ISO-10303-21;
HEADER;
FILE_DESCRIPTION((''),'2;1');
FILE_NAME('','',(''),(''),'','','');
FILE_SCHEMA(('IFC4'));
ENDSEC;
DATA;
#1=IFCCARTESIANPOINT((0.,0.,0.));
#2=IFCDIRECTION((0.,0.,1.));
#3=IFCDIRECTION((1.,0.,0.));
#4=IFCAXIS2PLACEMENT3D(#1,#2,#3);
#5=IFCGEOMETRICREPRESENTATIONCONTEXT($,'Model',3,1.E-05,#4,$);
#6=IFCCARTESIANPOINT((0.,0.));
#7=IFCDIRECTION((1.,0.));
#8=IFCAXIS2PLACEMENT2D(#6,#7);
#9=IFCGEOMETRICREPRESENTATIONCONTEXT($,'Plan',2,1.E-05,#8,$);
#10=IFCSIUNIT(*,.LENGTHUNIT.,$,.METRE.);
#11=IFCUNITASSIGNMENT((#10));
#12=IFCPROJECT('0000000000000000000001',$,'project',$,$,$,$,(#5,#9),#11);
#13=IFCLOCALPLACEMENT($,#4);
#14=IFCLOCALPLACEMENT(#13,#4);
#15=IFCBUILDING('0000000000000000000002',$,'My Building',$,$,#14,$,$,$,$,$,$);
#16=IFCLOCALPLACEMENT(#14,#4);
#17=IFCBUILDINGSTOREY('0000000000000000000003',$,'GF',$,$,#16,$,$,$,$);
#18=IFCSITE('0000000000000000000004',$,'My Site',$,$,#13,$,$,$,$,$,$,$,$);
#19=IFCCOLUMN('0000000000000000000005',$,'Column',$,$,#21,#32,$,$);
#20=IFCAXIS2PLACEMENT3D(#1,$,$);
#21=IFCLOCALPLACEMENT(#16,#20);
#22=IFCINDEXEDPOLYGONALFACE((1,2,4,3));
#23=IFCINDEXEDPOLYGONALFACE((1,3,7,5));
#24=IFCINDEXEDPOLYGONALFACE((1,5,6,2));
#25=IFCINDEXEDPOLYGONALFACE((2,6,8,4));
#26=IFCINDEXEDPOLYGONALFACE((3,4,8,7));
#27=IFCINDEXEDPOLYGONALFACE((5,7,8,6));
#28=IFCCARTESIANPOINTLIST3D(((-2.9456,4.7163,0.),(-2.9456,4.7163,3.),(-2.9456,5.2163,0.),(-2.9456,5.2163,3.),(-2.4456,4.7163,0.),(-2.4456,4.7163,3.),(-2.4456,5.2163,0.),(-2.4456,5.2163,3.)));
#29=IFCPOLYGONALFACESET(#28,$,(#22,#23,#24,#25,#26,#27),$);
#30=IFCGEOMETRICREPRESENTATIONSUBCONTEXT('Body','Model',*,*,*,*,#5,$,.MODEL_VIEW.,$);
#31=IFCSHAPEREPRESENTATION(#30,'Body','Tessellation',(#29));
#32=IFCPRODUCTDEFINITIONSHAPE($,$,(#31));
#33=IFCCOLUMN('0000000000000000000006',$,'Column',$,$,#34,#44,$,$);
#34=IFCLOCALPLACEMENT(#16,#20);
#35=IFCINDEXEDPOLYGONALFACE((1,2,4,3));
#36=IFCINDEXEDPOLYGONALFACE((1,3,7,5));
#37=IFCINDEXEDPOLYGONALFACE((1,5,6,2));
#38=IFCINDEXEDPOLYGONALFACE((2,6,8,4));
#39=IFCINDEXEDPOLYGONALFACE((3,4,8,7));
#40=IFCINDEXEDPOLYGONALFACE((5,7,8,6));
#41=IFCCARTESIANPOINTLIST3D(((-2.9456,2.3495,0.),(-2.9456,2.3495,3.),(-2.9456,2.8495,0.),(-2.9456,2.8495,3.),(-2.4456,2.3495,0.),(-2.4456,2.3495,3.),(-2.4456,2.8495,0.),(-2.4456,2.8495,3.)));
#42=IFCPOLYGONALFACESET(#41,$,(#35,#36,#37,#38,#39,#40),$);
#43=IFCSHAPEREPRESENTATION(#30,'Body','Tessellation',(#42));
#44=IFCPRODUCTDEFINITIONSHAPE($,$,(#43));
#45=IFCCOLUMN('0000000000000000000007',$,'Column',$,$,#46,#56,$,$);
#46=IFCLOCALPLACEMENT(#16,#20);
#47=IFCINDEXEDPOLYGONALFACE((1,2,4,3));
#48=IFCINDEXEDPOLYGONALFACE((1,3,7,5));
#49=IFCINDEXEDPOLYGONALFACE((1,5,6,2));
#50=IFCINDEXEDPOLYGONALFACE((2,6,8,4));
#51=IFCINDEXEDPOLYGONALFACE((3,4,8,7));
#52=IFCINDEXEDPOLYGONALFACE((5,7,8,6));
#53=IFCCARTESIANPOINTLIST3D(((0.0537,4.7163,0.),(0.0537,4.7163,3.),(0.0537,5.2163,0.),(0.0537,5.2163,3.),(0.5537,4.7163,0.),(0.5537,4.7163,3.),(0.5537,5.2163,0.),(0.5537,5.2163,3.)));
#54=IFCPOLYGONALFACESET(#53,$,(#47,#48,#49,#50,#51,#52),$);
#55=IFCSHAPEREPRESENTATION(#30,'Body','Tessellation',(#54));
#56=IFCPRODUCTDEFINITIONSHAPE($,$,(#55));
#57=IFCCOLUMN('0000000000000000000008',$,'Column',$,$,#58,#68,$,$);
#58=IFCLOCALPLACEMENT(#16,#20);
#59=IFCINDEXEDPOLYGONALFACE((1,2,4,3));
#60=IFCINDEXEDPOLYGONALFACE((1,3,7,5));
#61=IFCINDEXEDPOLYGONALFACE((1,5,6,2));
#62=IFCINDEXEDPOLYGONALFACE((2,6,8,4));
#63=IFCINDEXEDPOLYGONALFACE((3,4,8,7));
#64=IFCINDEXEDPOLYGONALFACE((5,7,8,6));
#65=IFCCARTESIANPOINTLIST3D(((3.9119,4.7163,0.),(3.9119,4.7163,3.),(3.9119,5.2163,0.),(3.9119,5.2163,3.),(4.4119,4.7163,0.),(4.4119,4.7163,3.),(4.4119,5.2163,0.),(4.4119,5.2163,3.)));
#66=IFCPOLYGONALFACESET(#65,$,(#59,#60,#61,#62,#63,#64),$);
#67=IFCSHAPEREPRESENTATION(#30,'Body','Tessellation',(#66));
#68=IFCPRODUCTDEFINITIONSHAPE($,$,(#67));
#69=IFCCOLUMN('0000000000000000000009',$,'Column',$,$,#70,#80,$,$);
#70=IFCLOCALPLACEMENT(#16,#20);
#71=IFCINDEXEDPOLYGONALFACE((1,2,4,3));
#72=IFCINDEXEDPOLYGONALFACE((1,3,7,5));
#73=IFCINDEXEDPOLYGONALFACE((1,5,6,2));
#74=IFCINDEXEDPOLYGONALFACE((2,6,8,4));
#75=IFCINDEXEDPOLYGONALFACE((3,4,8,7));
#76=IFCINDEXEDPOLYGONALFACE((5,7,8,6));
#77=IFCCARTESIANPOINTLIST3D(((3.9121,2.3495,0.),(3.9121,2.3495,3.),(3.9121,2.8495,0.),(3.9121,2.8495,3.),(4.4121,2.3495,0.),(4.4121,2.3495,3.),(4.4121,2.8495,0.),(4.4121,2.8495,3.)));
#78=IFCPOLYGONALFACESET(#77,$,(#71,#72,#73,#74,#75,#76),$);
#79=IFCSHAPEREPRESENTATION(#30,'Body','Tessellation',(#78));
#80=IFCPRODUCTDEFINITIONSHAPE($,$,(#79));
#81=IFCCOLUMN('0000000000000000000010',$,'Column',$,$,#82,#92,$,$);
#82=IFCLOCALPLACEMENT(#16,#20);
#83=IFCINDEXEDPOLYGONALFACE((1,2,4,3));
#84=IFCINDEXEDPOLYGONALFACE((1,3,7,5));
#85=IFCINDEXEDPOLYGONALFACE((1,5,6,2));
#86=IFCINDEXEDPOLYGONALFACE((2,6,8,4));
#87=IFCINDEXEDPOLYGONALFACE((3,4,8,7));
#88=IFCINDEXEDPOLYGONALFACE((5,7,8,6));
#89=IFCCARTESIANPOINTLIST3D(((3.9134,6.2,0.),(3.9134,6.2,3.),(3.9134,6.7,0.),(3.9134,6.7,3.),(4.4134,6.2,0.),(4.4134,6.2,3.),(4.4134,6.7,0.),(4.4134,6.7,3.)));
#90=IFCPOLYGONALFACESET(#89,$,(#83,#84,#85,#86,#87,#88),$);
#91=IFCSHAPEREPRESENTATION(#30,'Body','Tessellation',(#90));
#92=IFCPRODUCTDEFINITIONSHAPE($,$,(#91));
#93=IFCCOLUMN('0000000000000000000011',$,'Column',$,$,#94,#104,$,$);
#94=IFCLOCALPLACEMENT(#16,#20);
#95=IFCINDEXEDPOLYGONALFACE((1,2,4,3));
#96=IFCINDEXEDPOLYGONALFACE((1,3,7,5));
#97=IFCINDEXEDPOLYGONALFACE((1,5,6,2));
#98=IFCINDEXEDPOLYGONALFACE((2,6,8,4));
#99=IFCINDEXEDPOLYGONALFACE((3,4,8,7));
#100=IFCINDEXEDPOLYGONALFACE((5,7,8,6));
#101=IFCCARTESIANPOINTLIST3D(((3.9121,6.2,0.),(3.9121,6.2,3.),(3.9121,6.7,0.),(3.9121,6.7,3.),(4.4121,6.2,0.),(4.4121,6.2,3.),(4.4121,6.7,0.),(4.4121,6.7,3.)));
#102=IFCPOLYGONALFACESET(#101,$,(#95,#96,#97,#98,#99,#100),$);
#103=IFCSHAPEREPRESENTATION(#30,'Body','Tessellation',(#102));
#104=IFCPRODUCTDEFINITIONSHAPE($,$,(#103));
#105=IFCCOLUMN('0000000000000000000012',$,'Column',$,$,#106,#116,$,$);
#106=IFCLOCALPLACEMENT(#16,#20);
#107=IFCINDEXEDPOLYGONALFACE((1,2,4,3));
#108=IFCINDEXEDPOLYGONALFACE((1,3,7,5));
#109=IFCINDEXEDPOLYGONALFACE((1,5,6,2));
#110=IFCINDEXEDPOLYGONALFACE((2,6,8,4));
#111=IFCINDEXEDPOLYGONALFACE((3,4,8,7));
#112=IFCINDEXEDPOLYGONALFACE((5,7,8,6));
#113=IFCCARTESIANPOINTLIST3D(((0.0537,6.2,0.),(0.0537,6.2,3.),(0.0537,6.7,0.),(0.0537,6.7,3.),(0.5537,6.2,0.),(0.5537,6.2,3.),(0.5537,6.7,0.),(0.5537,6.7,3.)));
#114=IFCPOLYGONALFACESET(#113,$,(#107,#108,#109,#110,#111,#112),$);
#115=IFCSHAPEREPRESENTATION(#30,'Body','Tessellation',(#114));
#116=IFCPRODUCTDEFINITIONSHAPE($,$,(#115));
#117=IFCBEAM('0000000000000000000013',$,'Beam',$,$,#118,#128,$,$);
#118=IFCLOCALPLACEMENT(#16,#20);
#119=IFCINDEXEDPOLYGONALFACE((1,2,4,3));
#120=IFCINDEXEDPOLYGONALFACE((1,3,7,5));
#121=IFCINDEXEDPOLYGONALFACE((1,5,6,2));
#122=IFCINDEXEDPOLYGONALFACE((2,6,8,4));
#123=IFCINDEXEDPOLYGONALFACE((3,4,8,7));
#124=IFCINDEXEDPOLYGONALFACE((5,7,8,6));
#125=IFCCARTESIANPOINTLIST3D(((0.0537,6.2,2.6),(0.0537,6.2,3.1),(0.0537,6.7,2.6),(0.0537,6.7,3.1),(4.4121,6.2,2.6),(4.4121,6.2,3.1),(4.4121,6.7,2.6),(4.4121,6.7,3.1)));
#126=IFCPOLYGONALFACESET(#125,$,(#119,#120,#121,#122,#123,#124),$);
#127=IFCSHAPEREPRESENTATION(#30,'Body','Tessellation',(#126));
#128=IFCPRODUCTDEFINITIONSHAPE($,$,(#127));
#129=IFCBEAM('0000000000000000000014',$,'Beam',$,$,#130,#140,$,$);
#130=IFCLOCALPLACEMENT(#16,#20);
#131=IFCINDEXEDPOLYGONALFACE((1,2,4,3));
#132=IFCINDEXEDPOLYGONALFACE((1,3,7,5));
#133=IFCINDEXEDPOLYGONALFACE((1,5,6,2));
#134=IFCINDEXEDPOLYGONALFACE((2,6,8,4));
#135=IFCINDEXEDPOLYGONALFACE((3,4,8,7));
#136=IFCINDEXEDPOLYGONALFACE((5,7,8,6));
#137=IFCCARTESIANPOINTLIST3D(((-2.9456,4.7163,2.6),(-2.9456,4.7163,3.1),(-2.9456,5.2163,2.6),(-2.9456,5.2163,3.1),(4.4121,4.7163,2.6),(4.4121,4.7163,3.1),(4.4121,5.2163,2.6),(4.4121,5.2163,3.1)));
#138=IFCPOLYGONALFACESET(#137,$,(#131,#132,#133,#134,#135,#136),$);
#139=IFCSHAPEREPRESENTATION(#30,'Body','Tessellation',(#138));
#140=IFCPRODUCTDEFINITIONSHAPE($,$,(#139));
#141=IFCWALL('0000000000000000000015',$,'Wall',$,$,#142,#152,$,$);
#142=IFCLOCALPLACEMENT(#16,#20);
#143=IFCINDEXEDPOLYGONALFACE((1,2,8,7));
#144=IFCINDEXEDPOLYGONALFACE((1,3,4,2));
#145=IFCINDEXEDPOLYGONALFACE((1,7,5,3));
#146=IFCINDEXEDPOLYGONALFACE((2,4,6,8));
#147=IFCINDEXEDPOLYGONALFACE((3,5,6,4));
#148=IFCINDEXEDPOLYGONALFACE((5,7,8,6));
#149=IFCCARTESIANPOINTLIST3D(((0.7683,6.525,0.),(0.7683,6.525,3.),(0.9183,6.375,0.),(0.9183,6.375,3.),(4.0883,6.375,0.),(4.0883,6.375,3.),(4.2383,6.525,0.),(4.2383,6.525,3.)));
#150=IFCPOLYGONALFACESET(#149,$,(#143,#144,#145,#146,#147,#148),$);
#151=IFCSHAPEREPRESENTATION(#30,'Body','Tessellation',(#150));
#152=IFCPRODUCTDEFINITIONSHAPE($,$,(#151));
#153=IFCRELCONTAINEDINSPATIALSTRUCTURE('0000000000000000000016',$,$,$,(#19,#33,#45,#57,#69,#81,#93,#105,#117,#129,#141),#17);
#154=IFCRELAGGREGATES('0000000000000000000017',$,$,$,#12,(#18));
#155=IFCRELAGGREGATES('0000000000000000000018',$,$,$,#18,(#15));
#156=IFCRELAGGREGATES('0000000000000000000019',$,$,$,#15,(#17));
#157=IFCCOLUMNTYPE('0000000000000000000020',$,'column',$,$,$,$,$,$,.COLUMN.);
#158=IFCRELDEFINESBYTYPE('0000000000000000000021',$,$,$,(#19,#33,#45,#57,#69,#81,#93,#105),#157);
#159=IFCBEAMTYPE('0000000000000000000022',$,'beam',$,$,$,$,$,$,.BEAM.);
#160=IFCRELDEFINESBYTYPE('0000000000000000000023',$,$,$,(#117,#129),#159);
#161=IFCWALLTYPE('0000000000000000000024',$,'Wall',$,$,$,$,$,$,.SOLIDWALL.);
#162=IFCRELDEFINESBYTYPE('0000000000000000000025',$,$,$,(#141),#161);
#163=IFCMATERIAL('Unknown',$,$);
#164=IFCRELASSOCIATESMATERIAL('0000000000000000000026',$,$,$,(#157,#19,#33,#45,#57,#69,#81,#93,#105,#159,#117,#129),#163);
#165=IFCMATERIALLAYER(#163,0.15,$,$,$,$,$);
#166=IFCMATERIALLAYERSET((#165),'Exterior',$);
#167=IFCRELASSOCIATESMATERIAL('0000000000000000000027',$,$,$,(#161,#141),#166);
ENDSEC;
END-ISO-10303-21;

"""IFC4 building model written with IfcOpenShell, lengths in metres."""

from ifc_helpers import new_model, si_unit, frame, origin_with_axes, origin_2d_with_axis, place, context, subcontext, project, spatial, line, indexed_curve, rectangle, outline, extrude, material, layer, layer_set, layer_usage, material_profile, profile_set, profile_usage, type_object, element, save


model = new_model("IFC4")

# Units and contexts
model_context = context("Model", 3, precision=1e-05, world=origin_with_axes())
plan_context = context("Plan", 2, precision=1e-05, world=origin_2d_with_axis())
body_context_1 = subcontext(model_context, "Body", "Model", "MODEL_VIEW")
ifc_project = project(units=[si_unit("LENGTHUNIT", "METRE")], contexts=[model_context, plan_context])

# Site, building, storey
site_placement = place(None, origin_with_axes())
site = spatial("IfcSite", under=ifc_project, at=site_placement, Name="My Site")
building_placement = place(site_placement, origin_with_axes())
building = spatial("IfcBuilding", under=site, at=building_placement, Name="My Building")
storey_placement = place(building_placement, origin_with_axes())
storey = spatial("IfcBuildingStorey", under=building, at=storey_placement, Name="GF")

# Columns
ifc_material = material(Name="Unknown")
ifc_material_profile_1 = material_profile(ifc_material, rectangle(XDim=0.5, YDim=0.5))
ifc_profile_set_1 = profile_set([ifc_material_profile_1])
ifc_profile_usage_1 = profile_usage(ifc_profile_set_1, cardinal=5)
column_type = type_object("IfcColumnType", Name="column", PredefinedType="COLUMN", material=ifc_profile_set_1)
column_1_placement = place(storey_placement, frame((-2.6956, 4.9663, 0.0), z_axis=(0.0, 0.0, 1.0), x_axis=(1.0, 0.0, 0.0)))
element("IfcColumn", 1, at=column_1_placement, inside=storey, type_object=column_type, material=ifc_profile_usage_1, Name="Column", context=body_context_1, shape_type="SweptSolid", body=[
    extrude(rectangle(XDim=0.5, YDim=0.5), origin_with_axes(), (0.0, 0.0, 1.0), 3.0),
])
ifc_profile_usage_2 = profile_usage(ifc_profile_set_1, cardinal=5)
column_2_placement = place(storey_placement, frame((-2.6956, 2.5995, 0.0), z_axis=(0.0, 0.0, 1.0), x_axis=(1.0, 0.0, 0.0)))
element("IfcColumn", 2, at=column_2_placement, inside=storey, type_object=column_type, material=ifc_profile_usage_2, Name="Column", context=body_context_1, shape_type="SweptSolid", body=[
    extrude(rectangle(XDim=0.5, YDim=0.5), origin_with_axes(), (0.0, 0.0, 1.0), 3.0),
])
ifc_profile_usage_3 = profile_usage(ifc_profile_set_1, cardinal=5)
column_3_placement = place(storey_placement, frame((0.3037, 4.9663, 0.0), z_axis=(0.0, 0.0, 1.0), x_axis=(1.0, 0.0, 0.0)))
element("IfcColumn", 3, at=column_3_placement, inside=storey, type_object=column_type, material=ifc_profile_usage_3, Name="Column", context=body_context_1, shape_type="SweptSolid", body=[
    extrude(rectangle(XDim=0.5, YDim=0.5), origin_with_axes(), (0.0, 0.0, 1.0), 3.0),
])
ifc_profile_usage_4 = profile_usage(ifc_profile_set_1, cardinal=5)
column_4_placement = place(storey_placement, frame((4.1619, 4.9663, 0.0), z_axis=(0.0, 0.0, 1.0), x_axis=(1.0, 0.0, 0.0)))
element("IfcColumn", 4, at=column_4_placement, inside=storey, type_object=column_type, material=ifc_profile_usage_4, Name="Column", context=body_context_1, shape_type="SweptSolid", body=[
    extrude(rectangle(XDim=0.5, YDim=0.5), origin_with_axes(), (0.0, 0.0, 1.0), 3.0),
])
ifc_profile_usage_5 = profile_usage(ifc_profile_set_1, cardinal=5)
column_5_placement = place(storey_placement, frame((4.1621, 2.5995, 0.0), z_axis=(0.0, 0.0, 1.0), x_axis=(1.0, 0.0, 0.0)))
element("IfcColumn", 5, at=column_5_placement, inside=storey, type_object=column_type, material=ifc_profile_usage_5, Name="Column", context=body_context_1, shape_type="SweptSolid", body=[
    extrude(rectangle(XDim=0.5, YDim=0.5), origin_with_axes(), (0.0, 0.0, 1.0), 3.0),
])
ifc_profile_usage_6 = profile_usage(ifc_profile_set_1, cardinal=5)
column_6_placement = place(storey_placement, frame((4.1634, 6.45, 0.0), z_axis=(0.0, 0.0, 1.0), x_axis=(1.0, 0.0, 0.0)))
element("IfcColumn", 6, at=column_6_placement, inside=storey, type_object=column_type, material=ifc_profile_usage_6, Name="Column", context=body_context_1, shape_type="SweptSolid", body=[
    extrude(rectangle(XDim=0.5, YDim=0.5), origin_with_axes(), (0.0, 0.0, 1.0), 3.0),
])
ifc_profile_usage_7 = profile_usage(ifc_profile_set_1, cardinal=5)
column_7_placement = place(storey_placement, frame((4.1621, 6.45, 0.0), z_axis=(0.0, 0.0, 1.0), x_axis=(1.0, 0.0, 0.0)))
element("IfcColumn", 7, at=column_7_placement, inside=storey, type_object=column_type, material=ifc_profile_usage_7, Name="Column", context=body_context_1, shape_type="SweptSolid", body=[
    extrude(rectangle(XDim=0.5, YDim=0.5), origin_with_axes(), (0.0, 0.0, 1.0), 3.0),
])
ifc_profile_usage_8 = profile_usage(ifc_profile_set_1, cardinal=5)
column_8_placement = place(storey_placement, frame((0.3037, 6.45, 0.0), z_axis=(0.0, 0.0, 1.0), x_axis=(1.0, 0.0, 0.0)))
element("IfcColumn", 8, at=column_8_placement, inside=storey, type_object=column_type, material=ifc_profile_usage_8, Name="Column", context=body_context_1, shape_type="SweptSolid", body=[
    extrude(rectangle(XDim=0.5, YDim=0.5), origin_with_axes(), (0.0, 0.0, 1.0), 3.0),
])

# Beams
ifc_material_profile_2 = material_profile(ifc_material, rectangle(XDim=0.5, YDim=0.5))
ifc_profile_set_2 = profile_set([ifc_material_profile_2])
ifc_profile_usage_9 = profile_usage(ifc_profile_set_2, cardinal=9)
beam_type = type_object("IfcBeamType", Name="beam", PredefinedType="BEAM", material=ifc_profile_set_2)
beam_1_placement = place(storey_placement, frame((4.4121, 6.7, 3.1), z_axis=(-1.0, 0.0, 0.0), x_axis=(0.0, -1.0, 0.0)))
element("IfcBeam", 9, at=beam_1_placement, inside=storey, type_object=beam_type, material=ifc_profile_usage_9, Name="Beam", context=body_context_1, shape_type="SweptSolid", body=[
    extrude(rectangle(XDim=0.5, YDim=0.5), frame((0.25, -0.25, 0.0), z_axis=(0.0, 0.0, 1.0), x_axis=(1.0, 0.0, 0.0)), (0.0, 0.0, 1.0), 4.3584),
])
ifc_profile_usage_10 = profile_usage(ifc_profile_set_2, cardinal=9)
beam_2_placement = place(storey_placement, frame((-2.9456, 4.7163, 3.1), z_axis=(1.0, 0.0, 0.0), x_axis=(0.0, 1.0, 0.0)))
element("IfcBeam", 10, at=beam_2_placement, inside=storey, type_object=beam_type, material=ifc_profile_usage_10, Name="Beam", context=body_context_1, shape_type="SweptSolid", body=[
    extrude(rectangle(XDim=0.5, YDim=0.5), frame((0.25, -0.25, 0.0), z_axis=(0.0, 0.0, 1.0), x_axis=(1.0, 0.0, 0.0)), (0.0, 0.0, 1.0), 7.3577),
])

# Wall
ifc_layer_1 = layer(ifc_material, 0.15)
ifc_layer_set_1 = layer_set([ifc_layer_1], Name="Exterior")
ifc_layer_usage_1 = layer_usage(ifc_layer_set_1, "AXIS2", "POSITIVE", 0.0)
wall_type_1 = type_object("IfcWallType", Name="Wall", PredefinedType="SOLIDWALL", material=ifc_layer_set_1)
wall_1_placement = place(storey_placement, frame((4.2383, 6.525, 0.0), z_axis=(0.0, 0.0, 1.0), x_axis=(-1.0, 0.0, 0.0)))
element("IfcWall", 11, at=wall_1_placement, inside=storey, type_object=wall_type_1, material=ifc_layer_usage_1, Name="Wall", context=body_context_1, shape_type="SweptSolid", body=[
    extrude(outline(indexed_curve([(0.0, 0.0), (0.15, 0.15), (3.32, 0.15), (3.47, 0.0)], segments=[line(1, 2, 3, 4, 1)])), origin_with_axes(), (0.0, 0.0, 1.0), 3.0),
])

save(model, "model.ifc")
